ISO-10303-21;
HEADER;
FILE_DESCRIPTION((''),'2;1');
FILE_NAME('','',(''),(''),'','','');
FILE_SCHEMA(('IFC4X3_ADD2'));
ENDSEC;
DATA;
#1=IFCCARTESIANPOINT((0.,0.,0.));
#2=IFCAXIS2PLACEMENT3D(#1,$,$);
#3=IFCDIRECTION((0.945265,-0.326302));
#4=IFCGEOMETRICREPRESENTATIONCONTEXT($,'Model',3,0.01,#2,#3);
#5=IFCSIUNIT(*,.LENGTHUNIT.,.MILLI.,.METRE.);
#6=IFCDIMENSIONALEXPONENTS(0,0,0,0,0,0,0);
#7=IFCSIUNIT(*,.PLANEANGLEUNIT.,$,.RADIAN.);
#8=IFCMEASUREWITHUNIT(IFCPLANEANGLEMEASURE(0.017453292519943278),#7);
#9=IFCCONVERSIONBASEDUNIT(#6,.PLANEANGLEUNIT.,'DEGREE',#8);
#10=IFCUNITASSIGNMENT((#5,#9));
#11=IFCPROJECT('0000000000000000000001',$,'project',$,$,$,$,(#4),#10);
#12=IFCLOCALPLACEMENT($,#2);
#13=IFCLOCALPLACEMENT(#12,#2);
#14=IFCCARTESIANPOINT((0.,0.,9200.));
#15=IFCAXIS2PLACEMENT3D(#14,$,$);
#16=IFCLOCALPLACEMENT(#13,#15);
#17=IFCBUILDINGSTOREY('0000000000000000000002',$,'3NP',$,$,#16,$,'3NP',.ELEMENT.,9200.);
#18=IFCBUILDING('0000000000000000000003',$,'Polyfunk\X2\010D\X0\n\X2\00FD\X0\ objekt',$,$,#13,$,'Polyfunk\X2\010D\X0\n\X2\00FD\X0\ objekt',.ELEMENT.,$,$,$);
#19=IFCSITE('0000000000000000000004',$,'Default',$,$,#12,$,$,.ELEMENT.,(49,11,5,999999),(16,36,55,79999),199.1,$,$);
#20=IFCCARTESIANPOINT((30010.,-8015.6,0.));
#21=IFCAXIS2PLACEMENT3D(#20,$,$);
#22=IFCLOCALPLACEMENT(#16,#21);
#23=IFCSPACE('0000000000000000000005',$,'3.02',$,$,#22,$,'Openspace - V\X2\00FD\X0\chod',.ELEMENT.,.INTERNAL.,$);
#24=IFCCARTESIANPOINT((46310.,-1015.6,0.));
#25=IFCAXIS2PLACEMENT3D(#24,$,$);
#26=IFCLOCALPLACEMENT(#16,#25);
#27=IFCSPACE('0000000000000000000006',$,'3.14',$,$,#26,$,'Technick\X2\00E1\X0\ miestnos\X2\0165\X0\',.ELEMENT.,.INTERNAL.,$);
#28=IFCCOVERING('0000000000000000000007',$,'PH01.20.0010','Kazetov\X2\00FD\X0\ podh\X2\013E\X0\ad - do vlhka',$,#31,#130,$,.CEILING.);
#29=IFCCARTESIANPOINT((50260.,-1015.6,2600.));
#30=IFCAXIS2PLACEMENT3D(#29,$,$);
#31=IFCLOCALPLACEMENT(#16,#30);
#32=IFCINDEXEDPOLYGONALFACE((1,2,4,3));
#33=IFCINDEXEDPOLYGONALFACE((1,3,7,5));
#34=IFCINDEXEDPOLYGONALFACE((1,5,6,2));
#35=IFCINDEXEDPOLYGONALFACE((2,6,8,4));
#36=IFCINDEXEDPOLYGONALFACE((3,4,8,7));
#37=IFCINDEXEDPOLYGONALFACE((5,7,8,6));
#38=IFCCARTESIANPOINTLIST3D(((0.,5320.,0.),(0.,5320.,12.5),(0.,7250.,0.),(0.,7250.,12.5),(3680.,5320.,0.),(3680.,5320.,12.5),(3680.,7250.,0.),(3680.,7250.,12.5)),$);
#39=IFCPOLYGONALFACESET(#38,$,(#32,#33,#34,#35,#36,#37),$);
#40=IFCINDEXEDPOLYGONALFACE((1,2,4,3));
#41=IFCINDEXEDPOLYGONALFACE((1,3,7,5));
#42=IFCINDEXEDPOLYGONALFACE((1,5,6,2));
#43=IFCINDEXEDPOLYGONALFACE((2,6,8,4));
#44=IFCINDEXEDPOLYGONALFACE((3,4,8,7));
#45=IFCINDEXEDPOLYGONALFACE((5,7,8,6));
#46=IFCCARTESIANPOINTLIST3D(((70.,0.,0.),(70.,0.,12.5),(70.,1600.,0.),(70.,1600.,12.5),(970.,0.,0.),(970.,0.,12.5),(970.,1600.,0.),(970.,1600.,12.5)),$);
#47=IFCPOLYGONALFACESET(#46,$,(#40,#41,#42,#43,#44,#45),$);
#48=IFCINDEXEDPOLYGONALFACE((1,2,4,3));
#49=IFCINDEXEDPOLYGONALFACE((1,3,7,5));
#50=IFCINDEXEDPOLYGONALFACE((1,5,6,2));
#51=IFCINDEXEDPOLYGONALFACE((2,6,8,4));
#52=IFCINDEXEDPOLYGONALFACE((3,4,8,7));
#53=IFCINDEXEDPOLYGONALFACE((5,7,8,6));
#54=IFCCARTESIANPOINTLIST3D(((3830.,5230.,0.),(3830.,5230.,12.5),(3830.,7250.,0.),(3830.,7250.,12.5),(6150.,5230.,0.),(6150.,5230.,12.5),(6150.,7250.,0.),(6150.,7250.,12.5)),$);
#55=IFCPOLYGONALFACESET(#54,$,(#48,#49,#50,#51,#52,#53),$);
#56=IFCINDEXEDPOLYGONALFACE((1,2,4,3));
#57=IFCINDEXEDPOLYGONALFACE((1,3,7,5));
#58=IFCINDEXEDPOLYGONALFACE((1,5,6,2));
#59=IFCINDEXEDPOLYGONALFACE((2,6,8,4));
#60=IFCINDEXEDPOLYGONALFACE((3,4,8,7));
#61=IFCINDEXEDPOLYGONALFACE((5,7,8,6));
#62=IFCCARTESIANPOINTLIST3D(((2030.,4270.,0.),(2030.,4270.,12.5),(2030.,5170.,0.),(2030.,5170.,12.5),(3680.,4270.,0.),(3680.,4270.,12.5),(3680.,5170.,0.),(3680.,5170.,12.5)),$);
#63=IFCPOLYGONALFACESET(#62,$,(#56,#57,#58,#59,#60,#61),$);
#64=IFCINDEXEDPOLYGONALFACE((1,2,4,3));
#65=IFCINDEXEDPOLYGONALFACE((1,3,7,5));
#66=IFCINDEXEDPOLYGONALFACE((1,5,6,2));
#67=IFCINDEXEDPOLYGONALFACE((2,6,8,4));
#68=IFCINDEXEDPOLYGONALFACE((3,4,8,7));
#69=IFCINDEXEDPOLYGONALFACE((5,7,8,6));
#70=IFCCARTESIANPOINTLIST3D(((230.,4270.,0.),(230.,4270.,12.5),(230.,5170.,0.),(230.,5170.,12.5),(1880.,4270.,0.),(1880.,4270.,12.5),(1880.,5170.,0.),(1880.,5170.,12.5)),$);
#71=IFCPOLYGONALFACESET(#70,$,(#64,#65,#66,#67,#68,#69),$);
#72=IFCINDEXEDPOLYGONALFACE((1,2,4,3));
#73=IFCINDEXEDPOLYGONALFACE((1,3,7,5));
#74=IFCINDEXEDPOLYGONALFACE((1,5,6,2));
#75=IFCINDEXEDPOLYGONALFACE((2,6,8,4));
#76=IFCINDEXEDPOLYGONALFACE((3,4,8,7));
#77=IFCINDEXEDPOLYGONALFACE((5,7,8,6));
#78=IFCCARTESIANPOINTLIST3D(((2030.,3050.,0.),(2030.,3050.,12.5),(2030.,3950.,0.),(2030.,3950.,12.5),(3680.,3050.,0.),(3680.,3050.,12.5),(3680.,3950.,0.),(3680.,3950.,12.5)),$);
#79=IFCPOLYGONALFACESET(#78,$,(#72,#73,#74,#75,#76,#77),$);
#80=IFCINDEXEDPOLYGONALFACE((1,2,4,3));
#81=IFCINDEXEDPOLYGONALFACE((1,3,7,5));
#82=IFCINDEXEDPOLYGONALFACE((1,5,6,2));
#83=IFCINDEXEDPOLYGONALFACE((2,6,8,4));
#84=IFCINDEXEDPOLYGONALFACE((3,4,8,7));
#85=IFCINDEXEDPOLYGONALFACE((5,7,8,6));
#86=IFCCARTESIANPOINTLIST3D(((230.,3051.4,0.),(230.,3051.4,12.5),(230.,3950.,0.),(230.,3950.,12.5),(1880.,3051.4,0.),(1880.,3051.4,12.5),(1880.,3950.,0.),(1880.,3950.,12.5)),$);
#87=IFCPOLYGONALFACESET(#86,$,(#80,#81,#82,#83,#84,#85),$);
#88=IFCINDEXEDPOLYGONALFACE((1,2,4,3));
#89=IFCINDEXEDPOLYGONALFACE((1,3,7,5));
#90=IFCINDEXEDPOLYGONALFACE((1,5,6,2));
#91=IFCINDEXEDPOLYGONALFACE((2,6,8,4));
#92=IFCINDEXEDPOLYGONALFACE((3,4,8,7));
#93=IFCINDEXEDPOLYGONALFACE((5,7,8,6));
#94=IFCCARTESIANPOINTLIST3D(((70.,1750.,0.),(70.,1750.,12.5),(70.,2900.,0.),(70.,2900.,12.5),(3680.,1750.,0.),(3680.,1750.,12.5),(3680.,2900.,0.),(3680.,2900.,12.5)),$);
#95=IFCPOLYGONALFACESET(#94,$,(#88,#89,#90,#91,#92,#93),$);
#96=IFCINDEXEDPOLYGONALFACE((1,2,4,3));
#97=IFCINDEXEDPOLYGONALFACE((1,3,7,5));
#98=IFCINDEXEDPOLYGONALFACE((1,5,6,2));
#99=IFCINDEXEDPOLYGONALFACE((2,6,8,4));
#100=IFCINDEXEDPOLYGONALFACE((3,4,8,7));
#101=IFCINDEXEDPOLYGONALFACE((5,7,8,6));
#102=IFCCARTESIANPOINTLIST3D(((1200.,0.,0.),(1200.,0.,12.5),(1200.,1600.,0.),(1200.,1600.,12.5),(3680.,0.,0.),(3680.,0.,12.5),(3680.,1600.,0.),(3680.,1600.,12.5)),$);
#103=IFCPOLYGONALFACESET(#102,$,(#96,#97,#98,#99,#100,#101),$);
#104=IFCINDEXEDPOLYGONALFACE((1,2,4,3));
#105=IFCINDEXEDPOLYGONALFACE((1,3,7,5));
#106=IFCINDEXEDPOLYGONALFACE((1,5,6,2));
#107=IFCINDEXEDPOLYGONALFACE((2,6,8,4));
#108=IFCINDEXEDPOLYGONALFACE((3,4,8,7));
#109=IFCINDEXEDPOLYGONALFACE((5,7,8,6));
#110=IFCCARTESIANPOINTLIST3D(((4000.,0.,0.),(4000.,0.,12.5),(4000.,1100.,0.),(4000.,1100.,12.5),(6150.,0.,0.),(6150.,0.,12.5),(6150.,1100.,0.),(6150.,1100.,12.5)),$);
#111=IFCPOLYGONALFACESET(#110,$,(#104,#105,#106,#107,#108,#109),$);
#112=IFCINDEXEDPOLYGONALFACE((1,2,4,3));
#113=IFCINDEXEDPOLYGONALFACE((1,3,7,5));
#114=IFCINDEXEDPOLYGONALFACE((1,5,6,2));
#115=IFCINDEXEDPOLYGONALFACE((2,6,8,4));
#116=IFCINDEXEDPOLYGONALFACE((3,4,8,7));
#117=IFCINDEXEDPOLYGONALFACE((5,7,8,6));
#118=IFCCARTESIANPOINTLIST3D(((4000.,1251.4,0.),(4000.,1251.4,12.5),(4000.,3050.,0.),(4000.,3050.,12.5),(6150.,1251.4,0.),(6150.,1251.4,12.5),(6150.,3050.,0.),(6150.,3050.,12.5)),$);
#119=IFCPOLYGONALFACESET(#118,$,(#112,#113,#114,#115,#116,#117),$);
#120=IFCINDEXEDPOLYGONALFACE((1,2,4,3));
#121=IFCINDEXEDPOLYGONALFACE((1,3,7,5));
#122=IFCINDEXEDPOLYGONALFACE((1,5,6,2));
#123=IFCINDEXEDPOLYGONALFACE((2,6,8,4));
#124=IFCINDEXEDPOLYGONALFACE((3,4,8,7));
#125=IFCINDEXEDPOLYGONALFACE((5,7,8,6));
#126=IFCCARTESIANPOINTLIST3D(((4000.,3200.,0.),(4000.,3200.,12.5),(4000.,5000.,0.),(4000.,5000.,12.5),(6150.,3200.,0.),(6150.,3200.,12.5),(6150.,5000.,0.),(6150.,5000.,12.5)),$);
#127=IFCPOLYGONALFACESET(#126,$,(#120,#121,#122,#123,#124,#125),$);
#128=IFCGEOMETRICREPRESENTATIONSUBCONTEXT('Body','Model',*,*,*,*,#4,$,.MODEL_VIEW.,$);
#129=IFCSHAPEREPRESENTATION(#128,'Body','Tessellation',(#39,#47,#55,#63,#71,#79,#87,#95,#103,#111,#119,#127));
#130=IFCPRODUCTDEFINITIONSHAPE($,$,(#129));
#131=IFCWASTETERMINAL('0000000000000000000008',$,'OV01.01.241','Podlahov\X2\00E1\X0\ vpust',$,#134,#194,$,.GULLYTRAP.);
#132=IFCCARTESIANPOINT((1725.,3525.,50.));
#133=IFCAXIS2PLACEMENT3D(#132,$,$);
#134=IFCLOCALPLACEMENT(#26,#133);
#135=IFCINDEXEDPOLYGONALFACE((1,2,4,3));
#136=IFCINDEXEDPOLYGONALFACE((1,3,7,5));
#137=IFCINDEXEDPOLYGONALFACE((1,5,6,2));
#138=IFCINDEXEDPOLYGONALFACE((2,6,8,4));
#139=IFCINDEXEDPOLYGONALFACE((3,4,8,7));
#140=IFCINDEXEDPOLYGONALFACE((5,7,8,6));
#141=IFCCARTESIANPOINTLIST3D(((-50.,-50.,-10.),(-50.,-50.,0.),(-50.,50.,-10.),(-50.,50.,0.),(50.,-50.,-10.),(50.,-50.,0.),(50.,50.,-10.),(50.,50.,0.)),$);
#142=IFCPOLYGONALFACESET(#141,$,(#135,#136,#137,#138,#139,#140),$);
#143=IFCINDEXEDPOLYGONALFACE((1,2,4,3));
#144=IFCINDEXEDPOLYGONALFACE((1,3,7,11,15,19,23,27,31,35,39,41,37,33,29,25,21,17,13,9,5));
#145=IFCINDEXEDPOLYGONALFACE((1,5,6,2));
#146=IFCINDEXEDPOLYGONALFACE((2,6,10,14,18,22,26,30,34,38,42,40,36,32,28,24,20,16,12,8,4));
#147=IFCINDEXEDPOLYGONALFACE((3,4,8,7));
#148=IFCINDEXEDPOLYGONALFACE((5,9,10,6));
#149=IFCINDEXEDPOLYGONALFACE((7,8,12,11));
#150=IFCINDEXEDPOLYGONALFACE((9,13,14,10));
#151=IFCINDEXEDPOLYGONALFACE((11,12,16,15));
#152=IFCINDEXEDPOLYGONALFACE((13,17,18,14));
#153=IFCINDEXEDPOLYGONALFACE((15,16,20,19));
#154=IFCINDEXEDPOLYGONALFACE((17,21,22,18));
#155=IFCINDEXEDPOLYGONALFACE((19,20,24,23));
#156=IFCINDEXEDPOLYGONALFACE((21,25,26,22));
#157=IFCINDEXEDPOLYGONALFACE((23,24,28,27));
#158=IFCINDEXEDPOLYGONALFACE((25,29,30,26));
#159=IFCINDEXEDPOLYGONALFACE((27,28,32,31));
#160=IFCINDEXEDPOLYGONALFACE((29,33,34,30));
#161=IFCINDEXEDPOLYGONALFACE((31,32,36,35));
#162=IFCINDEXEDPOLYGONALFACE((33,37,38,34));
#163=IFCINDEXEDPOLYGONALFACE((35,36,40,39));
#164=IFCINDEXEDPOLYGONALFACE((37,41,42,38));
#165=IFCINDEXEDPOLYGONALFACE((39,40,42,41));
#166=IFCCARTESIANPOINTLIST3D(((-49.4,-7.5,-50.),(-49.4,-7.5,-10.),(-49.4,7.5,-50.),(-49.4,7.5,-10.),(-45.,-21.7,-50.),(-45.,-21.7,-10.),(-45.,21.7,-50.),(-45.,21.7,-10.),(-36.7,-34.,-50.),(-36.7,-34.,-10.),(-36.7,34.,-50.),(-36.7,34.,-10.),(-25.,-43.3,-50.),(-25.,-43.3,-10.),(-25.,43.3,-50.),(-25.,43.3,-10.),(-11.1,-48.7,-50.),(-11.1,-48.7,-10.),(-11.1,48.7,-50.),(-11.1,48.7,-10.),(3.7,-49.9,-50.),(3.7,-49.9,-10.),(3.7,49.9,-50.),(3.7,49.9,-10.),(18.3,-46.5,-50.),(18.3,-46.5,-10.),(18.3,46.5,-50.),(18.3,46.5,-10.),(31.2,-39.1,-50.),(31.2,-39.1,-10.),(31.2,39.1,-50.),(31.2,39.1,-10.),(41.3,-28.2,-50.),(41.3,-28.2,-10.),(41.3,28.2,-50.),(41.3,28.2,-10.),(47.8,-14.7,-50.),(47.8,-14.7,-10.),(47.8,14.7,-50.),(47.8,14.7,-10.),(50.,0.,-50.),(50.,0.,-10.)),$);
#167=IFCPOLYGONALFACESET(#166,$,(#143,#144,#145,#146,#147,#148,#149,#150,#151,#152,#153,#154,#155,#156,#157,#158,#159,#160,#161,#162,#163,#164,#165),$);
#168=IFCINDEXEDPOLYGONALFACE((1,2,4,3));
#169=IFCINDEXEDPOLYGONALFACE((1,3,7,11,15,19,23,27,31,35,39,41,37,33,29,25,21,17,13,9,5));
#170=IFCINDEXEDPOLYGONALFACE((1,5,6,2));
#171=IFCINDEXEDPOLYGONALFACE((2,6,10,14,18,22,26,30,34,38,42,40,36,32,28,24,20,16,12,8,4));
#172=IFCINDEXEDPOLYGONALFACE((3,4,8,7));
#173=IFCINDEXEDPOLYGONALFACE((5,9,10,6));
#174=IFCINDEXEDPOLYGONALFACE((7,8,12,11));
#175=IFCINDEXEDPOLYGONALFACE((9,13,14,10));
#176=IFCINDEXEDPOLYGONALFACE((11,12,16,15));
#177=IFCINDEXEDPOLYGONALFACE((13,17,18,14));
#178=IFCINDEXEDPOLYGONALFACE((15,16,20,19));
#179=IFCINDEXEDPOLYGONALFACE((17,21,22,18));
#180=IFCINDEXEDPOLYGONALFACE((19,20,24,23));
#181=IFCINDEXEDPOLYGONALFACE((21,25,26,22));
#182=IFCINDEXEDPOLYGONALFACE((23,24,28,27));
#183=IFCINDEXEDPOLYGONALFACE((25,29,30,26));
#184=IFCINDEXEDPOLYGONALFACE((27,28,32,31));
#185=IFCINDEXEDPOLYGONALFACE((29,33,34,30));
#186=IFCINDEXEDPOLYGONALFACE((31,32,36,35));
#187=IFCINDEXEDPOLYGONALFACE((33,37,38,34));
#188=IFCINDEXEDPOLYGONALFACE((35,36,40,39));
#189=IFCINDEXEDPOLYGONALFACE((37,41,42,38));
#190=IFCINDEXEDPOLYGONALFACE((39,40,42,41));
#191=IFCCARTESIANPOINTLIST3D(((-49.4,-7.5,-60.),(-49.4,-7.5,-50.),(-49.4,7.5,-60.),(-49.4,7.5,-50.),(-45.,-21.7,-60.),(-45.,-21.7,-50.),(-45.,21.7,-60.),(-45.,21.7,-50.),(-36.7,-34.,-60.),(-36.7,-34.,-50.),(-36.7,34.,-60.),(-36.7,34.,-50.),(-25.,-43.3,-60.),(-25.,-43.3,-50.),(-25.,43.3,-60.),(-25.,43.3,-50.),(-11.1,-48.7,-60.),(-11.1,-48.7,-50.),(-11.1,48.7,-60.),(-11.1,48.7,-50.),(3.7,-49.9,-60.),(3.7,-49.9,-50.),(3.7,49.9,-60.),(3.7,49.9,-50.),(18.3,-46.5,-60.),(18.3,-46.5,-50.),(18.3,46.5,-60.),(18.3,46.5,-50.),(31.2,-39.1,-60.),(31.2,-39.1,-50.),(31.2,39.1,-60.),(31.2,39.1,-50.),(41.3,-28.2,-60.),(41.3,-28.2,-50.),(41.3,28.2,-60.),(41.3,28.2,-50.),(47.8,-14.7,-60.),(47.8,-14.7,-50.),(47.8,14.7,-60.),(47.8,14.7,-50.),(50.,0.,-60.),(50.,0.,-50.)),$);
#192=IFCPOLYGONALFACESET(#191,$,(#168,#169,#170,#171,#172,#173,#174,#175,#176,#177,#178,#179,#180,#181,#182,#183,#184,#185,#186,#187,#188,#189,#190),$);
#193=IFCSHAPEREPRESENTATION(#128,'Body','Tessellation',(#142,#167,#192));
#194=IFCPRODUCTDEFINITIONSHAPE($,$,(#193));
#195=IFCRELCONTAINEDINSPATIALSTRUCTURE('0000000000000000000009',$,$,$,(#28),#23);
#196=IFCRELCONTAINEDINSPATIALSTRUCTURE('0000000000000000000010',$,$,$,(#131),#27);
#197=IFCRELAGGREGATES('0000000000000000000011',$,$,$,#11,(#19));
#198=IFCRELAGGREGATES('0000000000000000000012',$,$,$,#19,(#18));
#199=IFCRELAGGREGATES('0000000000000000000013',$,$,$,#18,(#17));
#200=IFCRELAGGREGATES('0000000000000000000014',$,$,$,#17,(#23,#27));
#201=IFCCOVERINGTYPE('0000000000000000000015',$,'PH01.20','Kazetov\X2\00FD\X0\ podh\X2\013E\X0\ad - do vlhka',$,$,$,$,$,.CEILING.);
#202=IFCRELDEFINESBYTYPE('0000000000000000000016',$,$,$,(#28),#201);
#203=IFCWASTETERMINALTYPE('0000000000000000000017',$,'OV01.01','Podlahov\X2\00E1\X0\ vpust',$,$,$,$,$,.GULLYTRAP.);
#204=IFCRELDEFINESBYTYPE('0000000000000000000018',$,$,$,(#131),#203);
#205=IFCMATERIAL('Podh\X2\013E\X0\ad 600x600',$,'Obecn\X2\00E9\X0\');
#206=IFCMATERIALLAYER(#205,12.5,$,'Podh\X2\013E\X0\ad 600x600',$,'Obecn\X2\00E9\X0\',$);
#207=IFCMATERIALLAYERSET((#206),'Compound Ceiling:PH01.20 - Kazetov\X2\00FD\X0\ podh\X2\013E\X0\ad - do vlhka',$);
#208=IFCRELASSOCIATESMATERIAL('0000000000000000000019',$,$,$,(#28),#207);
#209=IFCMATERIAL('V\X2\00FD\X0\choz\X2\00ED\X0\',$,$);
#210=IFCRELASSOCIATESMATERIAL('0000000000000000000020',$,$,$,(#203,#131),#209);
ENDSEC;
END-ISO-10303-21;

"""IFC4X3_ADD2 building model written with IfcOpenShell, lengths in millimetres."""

from ifc_helpers import new_model, entity, si_unit, converted_unit, direction, frame, frame_2d, origin, origin_2d_with_axis, place, context, subcontext, project, spatial, rectangle, circle, extrude, source, transform, mapped, material, layer, layer_set, layer_usage, type_object, type_shapes, element, save


model = new_model("IFC4X3_ADD2")

# Units and contexts
model_context = context("Model", 3, precision=0.01, world=origin(), true_north=direction((0.945265, -0.326302)))
body_context = subcontext(model_context, "Body", "Model", "MODEL_VIEW")
ifc_project = project(units=[si_unit("LENGTHUNIT", "METRE", prefix="MILLI"), converted_unit("PLANEANGLEUNIT", "DEGREE", entity("IfcPlaneAngleMeasure", 0.017453292519943278), si_unit("PLANEANGLEUNIT", "RADIAN"), dimensions=[0, 0, 0, 0, 0, 0, 0])], contexts=[model_context])

# Site, building, storey
site_placement = place(None, origin())
site = spatial("IfcSite", under=ifc_project, at=site_placement, Name="Default", CompositionType="ELEMENT", RefLatitude=(49, 11, 5, 999999), RefLongitude=(16, 36, 55, 79999), RefElevation=199.1)
building_placement = place(site_placement, origin())
building = spatial("IfcBuilding", under=site, at=building_placement, Name="Polyfunkčný objekt", LongName="Polyfunkčný objekt", CompositionType="ELEMENT")
storey_placement = place(building_placement, frame((0.0, 0.0, 9200.0)))
storey = spatial("IfcBuildingStorey", under=building, at=storey_placement, Name="3NP", LongName="3NP", CompositionType="ELEMENT", Elevation=9200.0)

# Shared definitions
space_1_placement = place(storey_placement, frame((30010.0, -8015.6, 0.0)))
space_1 = spatial("IfcSpace", under=storey, at=space_1_placement, Name="3.02", LongName="Openspace - Východ", CompositionType="ELEMENT", PredefinedType="INTERNAL")

# Covering
ifc_material_1 = material(Name="Podhľad 600x600", Category="Obecné")
ifc_layer_1 = layer(ifc_material_1, 12.5, Name="Podhľad 600x600", Category="Obecné")
ifc_layer_set_1 = layer_set([ifc_layer_1], Name="Compound Ceiling:PH01.20 - Kazetový podhľad - do vlhka")
ifc_layer_usage_1 = layer_usage(ifc_layer_set_1, "AXIS3", "NEGATIVE", 0.0)
covering_type = type_object("IfcCoveringType", Name="PH01.20", Description="Kazetový podhľad - do vlhka", PredefinedType="CEILING")
covering_placement = place(storey_placement, frame((50260.0, -1015.6, 2600.0)))
element("IfcCovering", 1, at=covering_placement, inside=space_1, type_object=covering_type, material=ifc_layer_usage_1, Name="PH01.20.0010", Description="Kazetový podhľad - do vlhka", PredefinedType="CEILING", context=body_context, shape_type="SweptSolid", body=[
    extrude(rectangle(XDim=1930.0, YDim=3680.0, at=frame_2d((0.0, 0.0), x_axis=(1.0, 0.0))), frame((1840.0, 6285.0, 0.0), z_axis=(0.0, 0.0, 1.0), x_axis=(0.0, -1.0, 0.0)), (0.0, 0.0, 1.0), 12.5),
    extrude(rectangle(XDim=1600.0, YDim=900.0, at=origin_2d_with_axis()), frame((520.0, 800.0, 0.0), z_axis=(0.0, 0.0, 1.0), x_axis=(0.0, 1.0, 0.0)), (0.0, 0.0, 1.0), 12.5),
    extrude(rectangle(XDim=2320.0, YDim=2020.0, at=frame_2d((0.0, 0.0), x_axis=(1.0, 0.0))), frame((4990.0, 6240.0, 0.0), z_axis=(0.0, 0.0, 1.0), x_axis=(-1.0, 0.0, 0.0)), (0.0, 0.0, 1.0), 12.5),
    extrude(rectangle(XDim=900.0, YDim=1650.0, at=frame_2d((0.0, 0.0), x_axis=(1.0, 0.0))), frame((2855.0, 4720.0, 0.0), z_axis=(0.0, 0.0, 1.0), x_axis=(0.0, 1.0, 0.0)), (0.0, 0.0, 1.0), 12.5),
    extrude(rectangle(XDim=1650.0, YDim=900.0, at=frame_2d((0.0, 0.0), x_axis=(1.0, 0.0))), frame((1055.0, 4720.0, 0.0), z_axis=(0.0, 0.0, 1.0), x_axis=(-1.0, 0.0, 0.0)), (0.0, 0.0, 1.0), 12.5),
    extrude(rectangle(XDim=900.0, YDim=1650.0, at=frame_2d((0.0, 0.0), x_axis=(1.0, 0.0))), frame((2855.0, 3500.0, 0.0), z_axis=(0.0, 0.0, 1.0), x_axis=(0.0, -1.0, 0.0)), (0.0, 0.0, 1.0), 12.5),
    extrude(rectangle(XDim=1650.0, YDim=898.6, at=frame_2d((0.0, 0.0), x_axis=(1.0, 0.0))), frame((1055.0, 3500.7, 0.0), z_axis=(0.0, 0.0, 1.0), x_axis=(-1.0, 0.0, 0.0)), (0.0, 0.0, 1.0), 12.5),
    extrude(rectangle(XDim=3610.0, YDim=1150.0, at=frame_2d((0.0, 0.0), x_axis=(1.0, 0.0))), frame((1875.0, 2325.0, 0.0), z_axis=(0.0, 0.0, 1.0), x_axis=(-1.0, 0.0, 0.0)), (0.0, 0.0, 1.0), 12.5),
    extrude(rectangle(XDim=2480.0, YDim=1600.0, at=origin_2d_with_axis()), frame((2440.0, 800.0, 0.0), z_axis=(0.0, 0.0, 1.0), x_axis=(-1.0, 0.0, 0.0)), (0.0, 0.0, 1.0), 12.5),
    extrude(rectangle(XDim=1100.0, YDim=2150.0, at=frame_2d((0.0, 0.0), x_axis=(1.0, 0.0))), frame((5075.0, 550.0, 0.0), z_axis=(0.0, 0.0, 1.0), x_axis=(0.0, 1.0, 0.0)), (0.0, 0.0, 1.0), 12.5),
    extrude(rectangle(XDim=1798.6, YDim=2150.0, at=origin_2d_with_axis()), frame((5075.0, 2150.7, 0.0), z_axis=(0.0, 0.0, 1.0), x_axis=(0.0, 1.0, 0.0)), (0.0, 0.0, 1.0), 12.5),
    extrude(rectangle(XDim=1800.0, YDim=2150.0, at=frame_2d((0.0, 0.0), x_axis=(1.0, 0.0))), frame((5075.0, 4100.0, 0.0), z_axis=(0.0, 0.0, 1.0), x_axis=(0.0, 1.0, 0.0)), (0.0, 0.0, 1.0), 12.5),
])

# Shared definitions
space_2_placement = place(storey_placement, frame((46310.0, -1015.6, 0.0)))
space_2 = spatial("IfcSpace", under=storey, at=space_2_placement, Name="3.14", LongName="Technická miestnosť", CompositionType="ELEMENT", PredefinedType="INTERNAL")

# Waste terminal
ifc_material_2 = material(Name="Výchozí")
waste_terminal_type = type_object("IfcWasteTerminalType", Name="OV01.01", Description="Podlahová vpust", PredefinedType="GULLYTRAP", material=ifc_material_2)
shared_shape_1 = source(origin(), body_context, "Body", "SweptSolid", [
    extrude(rectangle(XDim=100.0, YDim=100.0, at=frame_2d((0.0, 0.0), x_axis=(1.0, 0.0))), frame((0.0, 0.0, -10.0), z_axis=(0.0, 0.0, 1.0), x_axis=(-1.0, 0.0, 0.0)), (0.0, 0.0, 1.0), 10.0),
    extrude(circle(Radius=50.0, at=frame_2d((0.0, 0.0), x_axis=(1.0, 0.0))), frame((0.0, 0.0, -50.0)), (0.0, 0.0, 1.0), 40.0),
    extrude(circle(Radius=50.0, at=frame_2d((0.0, 0.0), x_axis=(1.0, 0.0))), frame((0.0, 0.0, -60.0)), (0.0, 0.0, 1.0), 10.0),
])
type_shapes(waste_terminal_type, [shared_shape_1])
waste_terminal_placement = place(space_2_placement, frame((1725.0, 3525.0, 50.0)))
element("IfcWasteTerminal", 2, at=waste_terminal_placement, inside=space_2, type_object=waste_terminal_type, material=ifc_material_2, Name="OV01.01.241", Description="Podlahová vpust", PredefinedType="GULLYTRAP", context=body_context, shape_type="MappedRepresentation", body=[
    mapped(shared_shape_1, transform((0.0, 0.0, 0.0), scale=1.0)),
])

save(model, "model.ifc")
